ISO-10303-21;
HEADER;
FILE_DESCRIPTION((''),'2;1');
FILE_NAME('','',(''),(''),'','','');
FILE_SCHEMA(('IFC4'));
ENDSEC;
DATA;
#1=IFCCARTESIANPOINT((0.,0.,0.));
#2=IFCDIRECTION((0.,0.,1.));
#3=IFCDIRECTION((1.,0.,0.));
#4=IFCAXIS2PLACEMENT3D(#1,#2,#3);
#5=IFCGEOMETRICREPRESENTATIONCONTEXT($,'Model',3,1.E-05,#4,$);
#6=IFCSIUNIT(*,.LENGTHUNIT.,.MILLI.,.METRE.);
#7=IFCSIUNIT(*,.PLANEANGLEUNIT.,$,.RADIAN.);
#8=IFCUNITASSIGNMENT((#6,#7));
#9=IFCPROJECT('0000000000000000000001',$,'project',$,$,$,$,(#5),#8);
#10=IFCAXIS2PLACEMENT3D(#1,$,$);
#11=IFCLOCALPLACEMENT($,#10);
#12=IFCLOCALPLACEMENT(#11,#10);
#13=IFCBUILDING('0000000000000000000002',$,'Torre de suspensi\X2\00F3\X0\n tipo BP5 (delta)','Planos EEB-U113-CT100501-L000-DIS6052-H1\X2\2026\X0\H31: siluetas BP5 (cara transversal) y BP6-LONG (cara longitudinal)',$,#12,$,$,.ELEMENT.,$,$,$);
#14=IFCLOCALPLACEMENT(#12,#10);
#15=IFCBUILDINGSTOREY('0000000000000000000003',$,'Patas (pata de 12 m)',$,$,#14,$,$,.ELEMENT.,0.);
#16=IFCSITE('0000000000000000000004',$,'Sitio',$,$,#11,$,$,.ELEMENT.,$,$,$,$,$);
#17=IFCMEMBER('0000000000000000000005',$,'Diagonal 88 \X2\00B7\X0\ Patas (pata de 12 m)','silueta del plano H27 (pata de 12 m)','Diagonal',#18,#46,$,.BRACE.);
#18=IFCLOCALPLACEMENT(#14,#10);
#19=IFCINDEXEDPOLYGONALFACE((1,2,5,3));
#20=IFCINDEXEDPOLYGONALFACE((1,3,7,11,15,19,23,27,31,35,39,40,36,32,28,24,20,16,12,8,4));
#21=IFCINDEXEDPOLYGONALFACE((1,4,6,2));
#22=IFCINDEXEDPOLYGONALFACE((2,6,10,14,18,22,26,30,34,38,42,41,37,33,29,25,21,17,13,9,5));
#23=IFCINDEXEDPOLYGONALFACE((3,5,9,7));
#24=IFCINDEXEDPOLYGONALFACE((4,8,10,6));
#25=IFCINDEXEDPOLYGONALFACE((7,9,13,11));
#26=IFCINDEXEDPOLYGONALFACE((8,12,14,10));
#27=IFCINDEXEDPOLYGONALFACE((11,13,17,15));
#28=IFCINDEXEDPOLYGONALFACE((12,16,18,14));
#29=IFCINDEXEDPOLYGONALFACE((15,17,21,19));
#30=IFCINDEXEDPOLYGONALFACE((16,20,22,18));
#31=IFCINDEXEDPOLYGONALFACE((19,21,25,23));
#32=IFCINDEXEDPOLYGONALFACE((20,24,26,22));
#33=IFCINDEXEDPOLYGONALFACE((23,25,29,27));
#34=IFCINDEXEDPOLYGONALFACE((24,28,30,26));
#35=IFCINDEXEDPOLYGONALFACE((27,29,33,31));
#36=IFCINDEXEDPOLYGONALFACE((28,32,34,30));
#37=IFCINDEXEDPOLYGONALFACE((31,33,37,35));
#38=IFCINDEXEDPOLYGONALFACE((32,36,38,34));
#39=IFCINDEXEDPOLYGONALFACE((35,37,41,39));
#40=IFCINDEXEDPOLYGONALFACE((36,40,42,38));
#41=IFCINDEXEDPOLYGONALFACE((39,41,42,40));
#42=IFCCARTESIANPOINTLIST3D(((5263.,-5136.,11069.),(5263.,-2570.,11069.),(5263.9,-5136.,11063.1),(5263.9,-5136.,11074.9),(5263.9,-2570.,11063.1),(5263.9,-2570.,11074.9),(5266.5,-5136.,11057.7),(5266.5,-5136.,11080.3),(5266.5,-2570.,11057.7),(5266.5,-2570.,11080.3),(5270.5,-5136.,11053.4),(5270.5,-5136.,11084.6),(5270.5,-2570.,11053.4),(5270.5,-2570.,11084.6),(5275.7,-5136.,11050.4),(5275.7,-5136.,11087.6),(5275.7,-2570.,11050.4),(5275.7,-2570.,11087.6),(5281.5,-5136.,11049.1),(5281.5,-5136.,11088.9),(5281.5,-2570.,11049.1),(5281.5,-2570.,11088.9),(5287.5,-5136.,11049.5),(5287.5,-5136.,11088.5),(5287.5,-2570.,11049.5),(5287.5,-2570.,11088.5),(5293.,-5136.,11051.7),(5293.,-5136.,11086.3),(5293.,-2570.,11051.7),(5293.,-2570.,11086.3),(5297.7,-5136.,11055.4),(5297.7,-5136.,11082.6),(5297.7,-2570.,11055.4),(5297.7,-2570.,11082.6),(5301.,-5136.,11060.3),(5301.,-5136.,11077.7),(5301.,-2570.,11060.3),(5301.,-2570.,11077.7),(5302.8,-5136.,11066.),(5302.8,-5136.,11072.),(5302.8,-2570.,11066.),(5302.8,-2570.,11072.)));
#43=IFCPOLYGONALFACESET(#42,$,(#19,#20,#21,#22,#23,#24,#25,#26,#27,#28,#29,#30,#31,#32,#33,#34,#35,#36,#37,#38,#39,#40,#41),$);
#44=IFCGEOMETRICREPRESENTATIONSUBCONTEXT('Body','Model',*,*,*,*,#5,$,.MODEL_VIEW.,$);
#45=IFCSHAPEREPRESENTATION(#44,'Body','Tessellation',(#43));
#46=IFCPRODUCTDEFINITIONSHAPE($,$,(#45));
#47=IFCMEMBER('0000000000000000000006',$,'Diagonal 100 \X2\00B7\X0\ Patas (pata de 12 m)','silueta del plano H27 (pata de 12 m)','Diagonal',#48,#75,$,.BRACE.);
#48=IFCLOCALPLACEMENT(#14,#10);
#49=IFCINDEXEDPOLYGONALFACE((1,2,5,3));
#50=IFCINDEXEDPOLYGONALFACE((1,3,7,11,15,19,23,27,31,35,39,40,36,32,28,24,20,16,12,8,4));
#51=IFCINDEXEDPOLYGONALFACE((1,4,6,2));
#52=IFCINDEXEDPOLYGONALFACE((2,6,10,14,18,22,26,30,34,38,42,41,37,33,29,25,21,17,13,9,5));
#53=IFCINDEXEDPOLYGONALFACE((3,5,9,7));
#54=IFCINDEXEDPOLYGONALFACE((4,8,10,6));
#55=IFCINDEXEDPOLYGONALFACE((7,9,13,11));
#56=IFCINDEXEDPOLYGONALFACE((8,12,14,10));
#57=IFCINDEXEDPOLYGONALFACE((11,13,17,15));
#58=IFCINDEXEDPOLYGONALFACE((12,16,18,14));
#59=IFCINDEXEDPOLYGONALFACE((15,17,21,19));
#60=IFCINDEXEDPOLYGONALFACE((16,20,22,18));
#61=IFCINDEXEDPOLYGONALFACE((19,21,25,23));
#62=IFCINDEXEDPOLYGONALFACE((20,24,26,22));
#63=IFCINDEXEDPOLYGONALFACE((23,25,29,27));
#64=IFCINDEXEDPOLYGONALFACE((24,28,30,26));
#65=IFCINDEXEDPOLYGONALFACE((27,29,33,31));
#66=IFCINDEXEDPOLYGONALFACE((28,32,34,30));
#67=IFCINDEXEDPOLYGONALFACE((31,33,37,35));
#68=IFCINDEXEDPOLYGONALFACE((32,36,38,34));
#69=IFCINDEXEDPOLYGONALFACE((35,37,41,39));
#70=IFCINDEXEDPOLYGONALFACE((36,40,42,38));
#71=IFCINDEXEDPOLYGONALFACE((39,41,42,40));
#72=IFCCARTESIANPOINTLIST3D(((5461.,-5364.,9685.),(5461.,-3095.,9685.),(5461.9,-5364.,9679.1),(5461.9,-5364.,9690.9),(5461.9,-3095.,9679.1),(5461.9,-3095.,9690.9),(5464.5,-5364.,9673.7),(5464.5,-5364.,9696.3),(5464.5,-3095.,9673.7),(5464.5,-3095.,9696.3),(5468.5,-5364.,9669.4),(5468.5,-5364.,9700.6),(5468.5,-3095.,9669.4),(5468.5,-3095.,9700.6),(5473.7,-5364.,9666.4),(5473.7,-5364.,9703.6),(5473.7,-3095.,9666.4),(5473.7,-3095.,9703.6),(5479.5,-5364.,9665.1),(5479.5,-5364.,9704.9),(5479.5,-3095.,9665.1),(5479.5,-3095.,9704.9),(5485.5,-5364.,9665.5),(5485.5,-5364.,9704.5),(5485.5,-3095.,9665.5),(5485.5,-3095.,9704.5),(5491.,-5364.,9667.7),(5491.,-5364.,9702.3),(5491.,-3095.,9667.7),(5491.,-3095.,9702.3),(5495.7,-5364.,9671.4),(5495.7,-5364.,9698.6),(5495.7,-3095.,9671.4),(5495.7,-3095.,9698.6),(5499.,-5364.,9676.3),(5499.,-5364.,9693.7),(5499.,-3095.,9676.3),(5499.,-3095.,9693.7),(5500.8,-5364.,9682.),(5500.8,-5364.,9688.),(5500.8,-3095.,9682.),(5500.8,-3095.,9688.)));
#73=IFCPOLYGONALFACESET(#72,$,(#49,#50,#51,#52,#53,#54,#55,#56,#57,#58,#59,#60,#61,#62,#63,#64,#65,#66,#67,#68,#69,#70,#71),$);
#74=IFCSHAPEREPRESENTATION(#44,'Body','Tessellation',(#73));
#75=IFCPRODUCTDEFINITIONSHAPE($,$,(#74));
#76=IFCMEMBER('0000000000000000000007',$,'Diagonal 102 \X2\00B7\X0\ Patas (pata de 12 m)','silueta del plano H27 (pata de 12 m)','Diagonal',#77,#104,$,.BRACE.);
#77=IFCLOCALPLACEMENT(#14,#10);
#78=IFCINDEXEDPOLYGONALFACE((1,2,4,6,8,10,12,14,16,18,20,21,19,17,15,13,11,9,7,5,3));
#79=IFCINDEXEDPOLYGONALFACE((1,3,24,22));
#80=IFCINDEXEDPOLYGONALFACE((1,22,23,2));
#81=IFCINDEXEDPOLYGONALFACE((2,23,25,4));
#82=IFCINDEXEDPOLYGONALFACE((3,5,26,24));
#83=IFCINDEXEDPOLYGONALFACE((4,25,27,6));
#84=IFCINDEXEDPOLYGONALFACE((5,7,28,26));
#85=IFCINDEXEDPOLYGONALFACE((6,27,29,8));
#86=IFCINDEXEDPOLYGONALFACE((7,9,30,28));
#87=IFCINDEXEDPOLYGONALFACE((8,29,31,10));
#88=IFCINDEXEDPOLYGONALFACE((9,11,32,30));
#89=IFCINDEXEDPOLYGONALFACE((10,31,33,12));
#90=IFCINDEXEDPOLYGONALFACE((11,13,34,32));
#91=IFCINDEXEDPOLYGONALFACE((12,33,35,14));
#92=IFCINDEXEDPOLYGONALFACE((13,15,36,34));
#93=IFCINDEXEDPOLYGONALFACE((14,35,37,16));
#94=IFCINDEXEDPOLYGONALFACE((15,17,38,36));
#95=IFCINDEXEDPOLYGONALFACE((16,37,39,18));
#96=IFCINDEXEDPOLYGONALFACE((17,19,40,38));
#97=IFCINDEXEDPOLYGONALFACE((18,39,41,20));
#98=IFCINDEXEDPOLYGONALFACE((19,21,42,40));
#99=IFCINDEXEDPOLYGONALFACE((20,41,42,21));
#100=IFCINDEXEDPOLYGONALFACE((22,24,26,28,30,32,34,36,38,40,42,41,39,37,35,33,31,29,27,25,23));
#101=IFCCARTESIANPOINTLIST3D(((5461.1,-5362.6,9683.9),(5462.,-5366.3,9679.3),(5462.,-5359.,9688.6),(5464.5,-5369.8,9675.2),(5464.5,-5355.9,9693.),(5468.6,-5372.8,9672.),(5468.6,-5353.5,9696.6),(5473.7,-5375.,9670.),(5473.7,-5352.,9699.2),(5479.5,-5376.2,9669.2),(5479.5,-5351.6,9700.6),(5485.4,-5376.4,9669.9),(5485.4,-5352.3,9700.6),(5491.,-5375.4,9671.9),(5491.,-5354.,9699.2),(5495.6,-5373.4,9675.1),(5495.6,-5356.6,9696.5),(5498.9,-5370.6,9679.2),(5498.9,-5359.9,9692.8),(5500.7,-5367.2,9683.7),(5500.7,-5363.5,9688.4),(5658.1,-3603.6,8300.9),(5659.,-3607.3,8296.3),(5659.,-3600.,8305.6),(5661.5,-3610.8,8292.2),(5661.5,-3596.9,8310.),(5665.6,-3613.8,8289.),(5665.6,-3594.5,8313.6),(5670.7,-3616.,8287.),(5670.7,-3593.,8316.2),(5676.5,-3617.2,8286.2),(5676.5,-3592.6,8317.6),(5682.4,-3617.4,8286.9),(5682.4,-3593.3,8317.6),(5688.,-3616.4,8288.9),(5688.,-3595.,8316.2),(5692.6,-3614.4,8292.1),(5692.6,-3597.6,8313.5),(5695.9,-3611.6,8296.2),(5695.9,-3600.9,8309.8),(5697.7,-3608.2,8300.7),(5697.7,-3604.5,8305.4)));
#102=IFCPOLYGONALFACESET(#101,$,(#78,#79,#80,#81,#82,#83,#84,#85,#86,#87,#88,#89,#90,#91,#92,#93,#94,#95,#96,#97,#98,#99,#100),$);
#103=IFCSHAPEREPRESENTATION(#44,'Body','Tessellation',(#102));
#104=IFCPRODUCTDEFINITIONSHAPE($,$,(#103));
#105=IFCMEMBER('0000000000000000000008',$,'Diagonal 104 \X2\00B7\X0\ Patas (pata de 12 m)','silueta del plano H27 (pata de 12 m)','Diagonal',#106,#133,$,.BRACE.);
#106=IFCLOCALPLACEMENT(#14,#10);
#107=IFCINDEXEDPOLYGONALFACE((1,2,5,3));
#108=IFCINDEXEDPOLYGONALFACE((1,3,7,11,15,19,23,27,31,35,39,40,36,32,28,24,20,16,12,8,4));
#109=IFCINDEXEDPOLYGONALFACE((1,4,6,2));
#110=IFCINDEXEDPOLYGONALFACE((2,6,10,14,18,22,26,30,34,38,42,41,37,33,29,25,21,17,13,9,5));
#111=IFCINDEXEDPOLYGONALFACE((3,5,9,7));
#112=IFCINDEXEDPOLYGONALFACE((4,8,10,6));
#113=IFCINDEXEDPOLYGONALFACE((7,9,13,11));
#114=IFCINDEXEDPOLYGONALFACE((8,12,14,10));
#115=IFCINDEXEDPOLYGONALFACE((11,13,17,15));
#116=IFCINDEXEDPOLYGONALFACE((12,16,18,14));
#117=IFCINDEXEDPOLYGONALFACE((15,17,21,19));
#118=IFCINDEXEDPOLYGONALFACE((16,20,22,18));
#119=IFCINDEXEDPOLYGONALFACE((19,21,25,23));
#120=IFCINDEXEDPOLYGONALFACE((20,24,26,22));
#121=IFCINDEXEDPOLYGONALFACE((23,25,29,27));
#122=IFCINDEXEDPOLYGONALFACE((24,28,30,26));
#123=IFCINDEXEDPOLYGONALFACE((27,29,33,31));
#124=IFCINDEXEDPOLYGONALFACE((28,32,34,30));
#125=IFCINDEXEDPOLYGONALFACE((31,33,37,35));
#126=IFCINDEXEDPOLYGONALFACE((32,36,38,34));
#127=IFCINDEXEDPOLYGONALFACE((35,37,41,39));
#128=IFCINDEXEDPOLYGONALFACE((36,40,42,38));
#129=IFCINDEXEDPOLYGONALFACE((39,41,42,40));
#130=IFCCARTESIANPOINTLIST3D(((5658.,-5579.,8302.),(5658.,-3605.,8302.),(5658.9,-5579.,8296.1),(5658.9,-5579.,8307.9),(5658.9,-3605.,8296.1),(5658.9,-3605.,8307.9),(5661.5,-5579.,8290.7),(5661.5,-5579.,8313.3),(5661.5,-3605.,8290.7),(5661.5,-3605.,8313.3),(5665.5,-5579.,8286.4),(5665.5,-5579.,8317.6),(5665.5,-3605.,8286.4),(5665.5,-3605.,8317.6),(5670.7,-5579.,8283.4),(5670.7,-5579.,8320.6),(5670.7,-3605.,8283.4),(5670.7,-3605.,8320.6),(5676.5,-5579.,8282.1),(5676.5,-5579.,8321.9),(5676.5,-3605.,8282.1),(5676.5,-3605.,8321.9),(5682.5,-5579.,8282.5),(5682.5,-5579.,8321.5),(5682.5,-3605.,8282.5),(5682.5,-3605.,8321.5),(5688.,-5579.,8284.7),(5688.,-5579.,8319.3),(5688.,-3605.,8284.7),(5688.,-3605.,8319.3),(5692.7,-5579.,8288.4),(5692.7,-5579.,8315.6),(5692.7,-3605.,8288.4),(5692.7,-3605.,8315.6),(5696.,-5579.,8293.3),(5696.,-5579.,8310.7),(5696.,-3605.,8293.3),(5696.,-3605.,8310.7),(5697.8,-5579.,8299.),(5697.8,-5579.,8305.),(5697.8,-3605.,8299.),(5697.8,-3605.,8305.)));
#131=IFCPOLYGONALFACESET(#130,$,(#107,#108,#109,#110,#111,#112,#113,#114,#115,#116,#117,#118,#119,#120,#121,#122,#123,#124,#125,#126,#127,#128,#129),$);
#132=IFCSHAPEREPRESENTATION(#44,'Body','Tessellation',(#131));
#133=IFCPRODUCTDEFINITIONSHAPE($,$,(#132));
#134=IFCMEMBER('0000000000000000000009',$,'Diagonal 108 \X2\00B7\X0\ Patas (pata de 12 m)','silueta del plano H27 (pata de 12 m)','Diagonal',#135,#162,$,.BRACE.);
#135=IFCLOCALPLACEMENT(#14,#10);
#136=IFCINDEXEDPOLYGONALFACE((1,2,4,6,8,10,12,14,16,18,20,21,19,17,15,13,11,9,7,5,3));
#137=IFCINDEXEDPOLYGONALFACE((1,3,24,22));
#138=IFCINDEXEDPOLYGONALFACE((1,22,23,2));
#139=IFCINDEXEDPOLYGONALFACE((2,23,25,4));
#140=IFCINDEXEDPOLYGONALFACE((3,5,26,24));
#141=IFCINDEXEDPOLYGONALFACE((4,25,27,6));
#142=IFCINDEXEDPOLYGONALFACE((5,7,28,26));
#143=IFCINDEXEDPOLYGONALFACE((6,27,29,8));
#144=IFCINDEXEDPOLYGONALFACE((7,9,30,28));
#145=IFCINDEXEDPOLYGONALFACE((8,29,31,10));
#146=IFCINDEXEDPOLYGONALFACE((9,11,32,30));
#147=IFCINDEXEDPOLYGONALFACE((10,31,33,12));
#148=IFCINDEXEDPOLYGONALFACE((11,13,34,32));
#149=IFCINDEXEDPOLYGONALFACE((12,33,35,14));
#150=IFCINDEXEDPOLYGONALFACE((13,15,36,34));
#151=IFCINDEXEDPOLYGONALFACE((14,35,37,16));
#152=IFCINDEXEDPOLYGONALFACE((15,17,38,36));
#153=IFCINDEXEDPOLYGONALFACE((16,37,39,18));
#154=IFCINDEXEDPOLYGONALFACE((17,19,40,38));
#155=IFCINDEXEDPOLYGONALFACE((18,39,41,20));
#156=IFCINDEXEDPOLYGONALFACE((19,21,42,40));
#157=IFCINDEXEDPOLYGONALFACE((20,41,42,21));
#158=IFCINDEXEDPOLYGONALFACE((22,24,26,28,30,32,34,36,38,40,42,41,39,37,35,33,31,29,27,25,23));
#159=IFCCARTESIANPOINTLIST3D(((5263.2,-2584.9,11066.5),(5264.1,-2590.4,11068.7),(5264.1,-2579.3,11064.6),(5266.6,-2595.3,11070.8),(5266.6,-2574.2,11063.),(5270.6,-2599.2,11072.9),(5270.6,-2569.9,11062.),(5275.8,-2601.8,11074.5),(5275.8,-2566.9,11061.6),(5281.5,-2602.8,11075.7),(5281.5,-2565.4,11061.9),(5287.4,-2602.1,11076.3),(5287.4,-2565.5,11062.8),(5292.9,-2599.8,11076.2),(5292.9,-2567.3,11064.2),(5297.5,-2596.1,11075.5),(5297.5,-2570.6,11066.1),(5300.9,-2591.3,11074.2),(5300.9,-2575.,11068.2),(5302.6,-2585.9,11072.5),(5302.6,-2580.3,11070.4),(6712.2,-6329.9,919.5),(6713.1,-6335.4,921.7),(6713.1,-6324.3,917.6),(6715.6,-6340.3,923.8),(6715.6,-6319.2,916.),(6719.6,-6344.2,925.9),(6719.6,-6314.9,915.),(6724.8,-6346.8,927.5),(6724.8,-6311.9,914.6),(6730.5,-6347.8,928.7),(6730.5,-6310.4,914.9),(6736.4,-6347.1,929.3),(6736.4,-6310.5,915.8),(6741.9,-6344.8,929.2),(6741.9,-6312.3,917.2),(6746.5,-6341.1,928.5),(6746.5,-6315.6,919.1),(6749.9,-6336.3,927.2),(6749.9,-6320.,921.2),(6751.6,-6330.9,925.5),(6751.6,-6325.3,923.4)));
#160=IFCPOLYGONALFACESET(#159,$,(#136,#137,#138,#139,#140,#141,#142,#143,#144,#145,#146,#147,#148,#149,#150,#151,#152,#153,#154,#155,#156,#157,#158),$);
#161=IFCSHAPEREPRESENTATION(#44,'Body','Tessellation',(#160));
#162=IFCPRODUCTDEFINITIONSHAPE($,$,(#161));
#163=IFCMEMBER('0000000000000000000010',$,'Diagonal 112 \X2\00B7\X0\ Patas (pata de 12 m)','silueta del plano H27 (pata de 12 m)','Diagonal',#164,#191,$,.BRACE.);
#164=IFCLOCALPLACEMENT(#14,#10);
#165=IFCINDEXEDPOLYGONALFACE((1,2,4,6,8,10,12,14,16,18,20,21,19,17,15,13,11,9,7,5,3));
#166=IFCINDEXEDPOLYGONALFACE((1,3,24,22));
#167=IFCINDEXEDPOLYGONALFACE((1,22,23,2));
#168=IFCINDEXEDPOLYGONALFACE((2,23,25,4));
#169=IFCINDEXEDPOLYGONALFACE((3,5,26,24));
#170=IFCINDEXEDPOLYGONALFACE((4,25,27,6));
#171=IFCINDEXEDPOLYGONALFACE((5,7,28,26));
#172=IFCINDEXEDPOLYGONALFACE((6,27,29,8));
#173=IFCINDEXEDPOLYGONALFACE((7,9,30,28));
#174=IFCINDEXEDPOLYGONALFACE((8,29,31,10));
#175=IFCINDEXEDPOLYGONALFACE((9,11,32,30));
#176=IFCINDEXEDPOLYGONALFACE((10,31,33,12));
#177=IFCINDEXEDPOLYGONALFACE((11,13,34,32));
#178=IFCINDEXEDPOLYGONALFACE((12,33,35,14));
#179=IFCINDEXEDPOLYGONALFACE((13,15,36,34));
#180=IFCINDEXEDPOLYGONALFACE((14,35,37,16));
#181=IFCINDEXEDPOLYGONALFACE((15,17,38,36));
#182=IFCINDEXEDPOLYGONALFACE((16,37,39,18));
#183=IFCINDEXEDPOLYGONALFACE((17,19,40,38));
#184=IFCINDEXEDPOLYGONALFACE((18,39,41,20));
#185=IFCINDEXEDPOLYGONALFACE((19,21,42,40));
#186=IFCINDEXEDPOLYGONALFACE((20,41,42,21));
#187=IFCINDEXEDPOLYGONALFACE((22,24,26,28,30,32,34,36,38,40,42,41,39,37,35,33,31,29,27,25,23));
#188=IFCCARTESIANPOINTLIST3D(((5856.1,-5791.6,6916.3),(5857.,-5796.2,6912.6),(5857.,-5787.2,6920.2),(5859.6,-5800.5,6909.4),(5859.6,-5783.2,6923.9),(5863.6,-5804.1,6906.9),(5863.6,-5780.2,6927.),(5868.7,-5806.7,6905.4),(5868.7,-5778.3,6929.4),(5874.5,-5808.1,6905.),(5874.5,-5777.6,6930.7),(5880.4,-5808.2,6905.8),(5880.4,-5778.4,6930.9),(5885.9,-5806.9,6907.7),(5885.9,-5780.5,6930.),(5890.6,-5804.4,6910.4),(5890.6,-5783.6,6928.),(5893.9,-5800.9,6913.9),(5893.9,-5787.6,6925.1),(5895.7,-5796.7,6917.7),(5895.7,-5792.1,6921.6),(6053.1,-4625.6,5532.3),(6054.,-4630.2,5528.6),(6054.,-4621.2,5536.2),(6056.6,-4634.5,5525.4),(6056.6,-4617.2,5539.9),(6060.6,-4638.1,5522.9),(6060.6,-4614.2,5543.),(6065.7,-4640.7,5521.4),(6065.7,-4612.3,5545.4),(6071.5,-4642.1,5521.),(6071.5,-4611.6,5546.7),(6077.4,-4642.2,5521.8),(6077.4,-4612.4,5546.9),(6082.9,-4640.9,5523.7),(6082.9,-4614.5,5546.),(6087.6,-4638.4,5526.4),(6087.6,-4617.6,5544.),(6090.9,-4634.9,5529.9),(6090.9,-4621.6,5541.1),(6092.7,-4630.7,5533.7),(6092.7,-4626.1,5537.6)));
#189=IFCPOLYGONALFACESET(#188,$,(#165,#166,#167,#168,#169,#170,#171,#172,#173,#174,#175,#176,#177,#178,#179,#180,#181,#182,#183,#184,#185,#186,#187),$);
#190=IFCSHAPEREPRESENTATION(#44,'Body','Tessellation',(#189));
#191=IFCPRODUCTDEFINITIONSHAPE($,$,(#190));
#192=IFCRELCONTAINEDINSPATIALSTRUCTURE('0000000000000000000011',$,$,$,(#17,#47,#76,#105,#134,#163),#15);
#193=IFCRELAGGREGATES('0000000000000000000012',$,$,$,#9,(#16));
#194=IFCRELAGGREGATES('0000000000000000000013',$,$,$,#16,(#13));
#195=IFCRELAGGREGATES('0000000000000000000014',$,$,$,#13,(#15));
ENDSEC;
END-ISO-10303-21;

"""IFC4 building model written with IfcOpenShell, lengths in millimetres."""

from ifc_helpers import new_model, si_unit, frame, origin, origin_with_axes, place, context, subcontext, project, spatial, circle, extrude, element, save


model = new_model("IFC4")

# Units and contexts
model_context = context("Model", 3, precision=1e-05, world=origin_with_axes())
body_context = subcontext(model_context, "Body", "Model", "MODEL_VIEW")
ifc_project = project(units=[si_unit("LENGTHUNIT", "METRE", prefix="MILLI"), si_unit("PLANEANGLEUNIT", "RADIAN")], contexts=[model_context])

# Site, building, storey
site_placement = place(None, origin())
site = spatial("IfcSite", under=ifc_project, at=site_placement, Name="Sitio", CompositionType="ELEMENT")
building_placement = place(site_placement, origin())
building = spatial("IfcBuilding", under=site, at=building_placement, Name="Torre de suspensión tipo BP5 (delta)", Description="Planos EEB-U113-CT100501-L000-DIS6052-H1…H31: siluetas BP5 (cara transversal) y BP6-LONG (cara longitudinal)", CompositionType="ELEMENT")
storey_placement = place(building_placement, origin())
storey = spatial("IfcBuildingStorey", under=building, at=storey_placement, Name="Patas (pata de 12 m)", CompositionType="ELEMENT", Elevation=0.0)

# Members
member_1_placement = place(storey_placement, frame((5283.0, -5136.0, 11069.0), z_axis=(0.0, 1.0, 0.0), x_axis=(-1.0, 0.0, 0.0)))
element("IfcMember", 1, at=member_1_placement, inside=storey, Name="Diagonal 88 · Patas (pata de 12 m)", Description="silueta del plano H27 (pata de 12 m)", ObjectType="Diagonal", PredefinedType="BRACE", context=body_context, shape_type="SweptSolid", body=[
    extrude(circle(Radius=20.0), None, (0.0, 0.0, 1.0), 2566.0),
])
member_2_placement = place(storey_placement, frame((5481.0, -3095.0, 9685.0), z_axis=(0.0, -1.0, 0.0), x_axis=(-1.0, 0.0, 0.0)))
element("IfcMember", 2, at=member_2_placement, inside=storey, Name="Diagonal 100 · Patas (pata de 12 m)", Description="silueta del plano H27 (pata de 12 m)", ObjectType="Diagonal", PredefinedType="BRACE", context=body_context, shape_type="SweptSolid", body=[
    extrude(circle(Radius=20.0), None, (0.0, 0.0, 1.0), 2269.0),
])
member_3_placement = place(storey_placement, frame((5678.0, -3605.0, 8302.0), z_axis=(-0.087702, -0.783088, 0.615696), x_axis=(-0.996147, 0.068944, -0.054207)))
element("IfcMember", 3, at=member_3_placement, inside=storey, Name="Diagonal 102 · Patas (pata de 12 m)", Description="silueta del plano H27 (pata de 12 m)", ObjectType="Diagonal", PredefinedType="BRACE", context=body_context, shape_type="SweptSolid", body=[
    extrude(circle(Radius=20.0), None, (0.0, 0.0, 1.0), 2246.2),
])
member_4_placement = place(storey_placement, frame((5678.0, -5579.0, 8302.0), z_axis=(0.0, 1.0, 0.0), x_axis=(-1.0, 0.0, 0.0)))
element("IfcMember", 4, at=member_4_placement, inside=storey, Name="Diagonal 104 · Patas (pata de 12 m)", Description="silueta del plano H27 (pata de 12 m)", ObjectType="Diagonal", PredefinedType="BRACE", context=body_context, shape_type="SweptSolid", body=[
    extrude(circle(Radius=20.0), None, (0.0, 0.0, 1.0), 1974.0),
])
member_5_placement = place(storey_placement, frame((5283.0, -2584.0, 11069.0), z_axis=(0.132782, -0.343179, -0.929837), x_axis=(-0.991145, -0.045975, -0.124568)))
element("IfcMember", 5, at=member_5_placement, inside=storey, Name="Diagonal 108 · Patas (pata de 12 m)", Description="silueta del plano H27 (pata de 12 m)", ObjectType="Diagonal", PredefinedType="BRACE", context=body_context, shape_type="SweptSolid", body=[
    extrude(circle(Radius=20.0), None, (0.0, 0.0, 1.0), 10912.7),
])
member_6_placement = place(storey_placement, frame((6073.0, -4627.0, 5534.0), z_axis=(-0.108219, -0.640522, 0.760277), x_axis=(-0.994127, 0.069726, -0.082762)))
element("IfcMember", 6, at=member_6_placement, inside=storey, Name="Diagonal 112 · Patas (pata de 12 m)", Description="silueta del plano H27 (pata de 12 m)", ObjectType="Diagonal", PredefinedType="BRACE", context=body_context, shape_type="SweptSolid", body=[
    extrude(circle(Radius=20.0), None, (0.0, 0.0, 1.0), 1820.4),
])

save(model, "model.ifc")
